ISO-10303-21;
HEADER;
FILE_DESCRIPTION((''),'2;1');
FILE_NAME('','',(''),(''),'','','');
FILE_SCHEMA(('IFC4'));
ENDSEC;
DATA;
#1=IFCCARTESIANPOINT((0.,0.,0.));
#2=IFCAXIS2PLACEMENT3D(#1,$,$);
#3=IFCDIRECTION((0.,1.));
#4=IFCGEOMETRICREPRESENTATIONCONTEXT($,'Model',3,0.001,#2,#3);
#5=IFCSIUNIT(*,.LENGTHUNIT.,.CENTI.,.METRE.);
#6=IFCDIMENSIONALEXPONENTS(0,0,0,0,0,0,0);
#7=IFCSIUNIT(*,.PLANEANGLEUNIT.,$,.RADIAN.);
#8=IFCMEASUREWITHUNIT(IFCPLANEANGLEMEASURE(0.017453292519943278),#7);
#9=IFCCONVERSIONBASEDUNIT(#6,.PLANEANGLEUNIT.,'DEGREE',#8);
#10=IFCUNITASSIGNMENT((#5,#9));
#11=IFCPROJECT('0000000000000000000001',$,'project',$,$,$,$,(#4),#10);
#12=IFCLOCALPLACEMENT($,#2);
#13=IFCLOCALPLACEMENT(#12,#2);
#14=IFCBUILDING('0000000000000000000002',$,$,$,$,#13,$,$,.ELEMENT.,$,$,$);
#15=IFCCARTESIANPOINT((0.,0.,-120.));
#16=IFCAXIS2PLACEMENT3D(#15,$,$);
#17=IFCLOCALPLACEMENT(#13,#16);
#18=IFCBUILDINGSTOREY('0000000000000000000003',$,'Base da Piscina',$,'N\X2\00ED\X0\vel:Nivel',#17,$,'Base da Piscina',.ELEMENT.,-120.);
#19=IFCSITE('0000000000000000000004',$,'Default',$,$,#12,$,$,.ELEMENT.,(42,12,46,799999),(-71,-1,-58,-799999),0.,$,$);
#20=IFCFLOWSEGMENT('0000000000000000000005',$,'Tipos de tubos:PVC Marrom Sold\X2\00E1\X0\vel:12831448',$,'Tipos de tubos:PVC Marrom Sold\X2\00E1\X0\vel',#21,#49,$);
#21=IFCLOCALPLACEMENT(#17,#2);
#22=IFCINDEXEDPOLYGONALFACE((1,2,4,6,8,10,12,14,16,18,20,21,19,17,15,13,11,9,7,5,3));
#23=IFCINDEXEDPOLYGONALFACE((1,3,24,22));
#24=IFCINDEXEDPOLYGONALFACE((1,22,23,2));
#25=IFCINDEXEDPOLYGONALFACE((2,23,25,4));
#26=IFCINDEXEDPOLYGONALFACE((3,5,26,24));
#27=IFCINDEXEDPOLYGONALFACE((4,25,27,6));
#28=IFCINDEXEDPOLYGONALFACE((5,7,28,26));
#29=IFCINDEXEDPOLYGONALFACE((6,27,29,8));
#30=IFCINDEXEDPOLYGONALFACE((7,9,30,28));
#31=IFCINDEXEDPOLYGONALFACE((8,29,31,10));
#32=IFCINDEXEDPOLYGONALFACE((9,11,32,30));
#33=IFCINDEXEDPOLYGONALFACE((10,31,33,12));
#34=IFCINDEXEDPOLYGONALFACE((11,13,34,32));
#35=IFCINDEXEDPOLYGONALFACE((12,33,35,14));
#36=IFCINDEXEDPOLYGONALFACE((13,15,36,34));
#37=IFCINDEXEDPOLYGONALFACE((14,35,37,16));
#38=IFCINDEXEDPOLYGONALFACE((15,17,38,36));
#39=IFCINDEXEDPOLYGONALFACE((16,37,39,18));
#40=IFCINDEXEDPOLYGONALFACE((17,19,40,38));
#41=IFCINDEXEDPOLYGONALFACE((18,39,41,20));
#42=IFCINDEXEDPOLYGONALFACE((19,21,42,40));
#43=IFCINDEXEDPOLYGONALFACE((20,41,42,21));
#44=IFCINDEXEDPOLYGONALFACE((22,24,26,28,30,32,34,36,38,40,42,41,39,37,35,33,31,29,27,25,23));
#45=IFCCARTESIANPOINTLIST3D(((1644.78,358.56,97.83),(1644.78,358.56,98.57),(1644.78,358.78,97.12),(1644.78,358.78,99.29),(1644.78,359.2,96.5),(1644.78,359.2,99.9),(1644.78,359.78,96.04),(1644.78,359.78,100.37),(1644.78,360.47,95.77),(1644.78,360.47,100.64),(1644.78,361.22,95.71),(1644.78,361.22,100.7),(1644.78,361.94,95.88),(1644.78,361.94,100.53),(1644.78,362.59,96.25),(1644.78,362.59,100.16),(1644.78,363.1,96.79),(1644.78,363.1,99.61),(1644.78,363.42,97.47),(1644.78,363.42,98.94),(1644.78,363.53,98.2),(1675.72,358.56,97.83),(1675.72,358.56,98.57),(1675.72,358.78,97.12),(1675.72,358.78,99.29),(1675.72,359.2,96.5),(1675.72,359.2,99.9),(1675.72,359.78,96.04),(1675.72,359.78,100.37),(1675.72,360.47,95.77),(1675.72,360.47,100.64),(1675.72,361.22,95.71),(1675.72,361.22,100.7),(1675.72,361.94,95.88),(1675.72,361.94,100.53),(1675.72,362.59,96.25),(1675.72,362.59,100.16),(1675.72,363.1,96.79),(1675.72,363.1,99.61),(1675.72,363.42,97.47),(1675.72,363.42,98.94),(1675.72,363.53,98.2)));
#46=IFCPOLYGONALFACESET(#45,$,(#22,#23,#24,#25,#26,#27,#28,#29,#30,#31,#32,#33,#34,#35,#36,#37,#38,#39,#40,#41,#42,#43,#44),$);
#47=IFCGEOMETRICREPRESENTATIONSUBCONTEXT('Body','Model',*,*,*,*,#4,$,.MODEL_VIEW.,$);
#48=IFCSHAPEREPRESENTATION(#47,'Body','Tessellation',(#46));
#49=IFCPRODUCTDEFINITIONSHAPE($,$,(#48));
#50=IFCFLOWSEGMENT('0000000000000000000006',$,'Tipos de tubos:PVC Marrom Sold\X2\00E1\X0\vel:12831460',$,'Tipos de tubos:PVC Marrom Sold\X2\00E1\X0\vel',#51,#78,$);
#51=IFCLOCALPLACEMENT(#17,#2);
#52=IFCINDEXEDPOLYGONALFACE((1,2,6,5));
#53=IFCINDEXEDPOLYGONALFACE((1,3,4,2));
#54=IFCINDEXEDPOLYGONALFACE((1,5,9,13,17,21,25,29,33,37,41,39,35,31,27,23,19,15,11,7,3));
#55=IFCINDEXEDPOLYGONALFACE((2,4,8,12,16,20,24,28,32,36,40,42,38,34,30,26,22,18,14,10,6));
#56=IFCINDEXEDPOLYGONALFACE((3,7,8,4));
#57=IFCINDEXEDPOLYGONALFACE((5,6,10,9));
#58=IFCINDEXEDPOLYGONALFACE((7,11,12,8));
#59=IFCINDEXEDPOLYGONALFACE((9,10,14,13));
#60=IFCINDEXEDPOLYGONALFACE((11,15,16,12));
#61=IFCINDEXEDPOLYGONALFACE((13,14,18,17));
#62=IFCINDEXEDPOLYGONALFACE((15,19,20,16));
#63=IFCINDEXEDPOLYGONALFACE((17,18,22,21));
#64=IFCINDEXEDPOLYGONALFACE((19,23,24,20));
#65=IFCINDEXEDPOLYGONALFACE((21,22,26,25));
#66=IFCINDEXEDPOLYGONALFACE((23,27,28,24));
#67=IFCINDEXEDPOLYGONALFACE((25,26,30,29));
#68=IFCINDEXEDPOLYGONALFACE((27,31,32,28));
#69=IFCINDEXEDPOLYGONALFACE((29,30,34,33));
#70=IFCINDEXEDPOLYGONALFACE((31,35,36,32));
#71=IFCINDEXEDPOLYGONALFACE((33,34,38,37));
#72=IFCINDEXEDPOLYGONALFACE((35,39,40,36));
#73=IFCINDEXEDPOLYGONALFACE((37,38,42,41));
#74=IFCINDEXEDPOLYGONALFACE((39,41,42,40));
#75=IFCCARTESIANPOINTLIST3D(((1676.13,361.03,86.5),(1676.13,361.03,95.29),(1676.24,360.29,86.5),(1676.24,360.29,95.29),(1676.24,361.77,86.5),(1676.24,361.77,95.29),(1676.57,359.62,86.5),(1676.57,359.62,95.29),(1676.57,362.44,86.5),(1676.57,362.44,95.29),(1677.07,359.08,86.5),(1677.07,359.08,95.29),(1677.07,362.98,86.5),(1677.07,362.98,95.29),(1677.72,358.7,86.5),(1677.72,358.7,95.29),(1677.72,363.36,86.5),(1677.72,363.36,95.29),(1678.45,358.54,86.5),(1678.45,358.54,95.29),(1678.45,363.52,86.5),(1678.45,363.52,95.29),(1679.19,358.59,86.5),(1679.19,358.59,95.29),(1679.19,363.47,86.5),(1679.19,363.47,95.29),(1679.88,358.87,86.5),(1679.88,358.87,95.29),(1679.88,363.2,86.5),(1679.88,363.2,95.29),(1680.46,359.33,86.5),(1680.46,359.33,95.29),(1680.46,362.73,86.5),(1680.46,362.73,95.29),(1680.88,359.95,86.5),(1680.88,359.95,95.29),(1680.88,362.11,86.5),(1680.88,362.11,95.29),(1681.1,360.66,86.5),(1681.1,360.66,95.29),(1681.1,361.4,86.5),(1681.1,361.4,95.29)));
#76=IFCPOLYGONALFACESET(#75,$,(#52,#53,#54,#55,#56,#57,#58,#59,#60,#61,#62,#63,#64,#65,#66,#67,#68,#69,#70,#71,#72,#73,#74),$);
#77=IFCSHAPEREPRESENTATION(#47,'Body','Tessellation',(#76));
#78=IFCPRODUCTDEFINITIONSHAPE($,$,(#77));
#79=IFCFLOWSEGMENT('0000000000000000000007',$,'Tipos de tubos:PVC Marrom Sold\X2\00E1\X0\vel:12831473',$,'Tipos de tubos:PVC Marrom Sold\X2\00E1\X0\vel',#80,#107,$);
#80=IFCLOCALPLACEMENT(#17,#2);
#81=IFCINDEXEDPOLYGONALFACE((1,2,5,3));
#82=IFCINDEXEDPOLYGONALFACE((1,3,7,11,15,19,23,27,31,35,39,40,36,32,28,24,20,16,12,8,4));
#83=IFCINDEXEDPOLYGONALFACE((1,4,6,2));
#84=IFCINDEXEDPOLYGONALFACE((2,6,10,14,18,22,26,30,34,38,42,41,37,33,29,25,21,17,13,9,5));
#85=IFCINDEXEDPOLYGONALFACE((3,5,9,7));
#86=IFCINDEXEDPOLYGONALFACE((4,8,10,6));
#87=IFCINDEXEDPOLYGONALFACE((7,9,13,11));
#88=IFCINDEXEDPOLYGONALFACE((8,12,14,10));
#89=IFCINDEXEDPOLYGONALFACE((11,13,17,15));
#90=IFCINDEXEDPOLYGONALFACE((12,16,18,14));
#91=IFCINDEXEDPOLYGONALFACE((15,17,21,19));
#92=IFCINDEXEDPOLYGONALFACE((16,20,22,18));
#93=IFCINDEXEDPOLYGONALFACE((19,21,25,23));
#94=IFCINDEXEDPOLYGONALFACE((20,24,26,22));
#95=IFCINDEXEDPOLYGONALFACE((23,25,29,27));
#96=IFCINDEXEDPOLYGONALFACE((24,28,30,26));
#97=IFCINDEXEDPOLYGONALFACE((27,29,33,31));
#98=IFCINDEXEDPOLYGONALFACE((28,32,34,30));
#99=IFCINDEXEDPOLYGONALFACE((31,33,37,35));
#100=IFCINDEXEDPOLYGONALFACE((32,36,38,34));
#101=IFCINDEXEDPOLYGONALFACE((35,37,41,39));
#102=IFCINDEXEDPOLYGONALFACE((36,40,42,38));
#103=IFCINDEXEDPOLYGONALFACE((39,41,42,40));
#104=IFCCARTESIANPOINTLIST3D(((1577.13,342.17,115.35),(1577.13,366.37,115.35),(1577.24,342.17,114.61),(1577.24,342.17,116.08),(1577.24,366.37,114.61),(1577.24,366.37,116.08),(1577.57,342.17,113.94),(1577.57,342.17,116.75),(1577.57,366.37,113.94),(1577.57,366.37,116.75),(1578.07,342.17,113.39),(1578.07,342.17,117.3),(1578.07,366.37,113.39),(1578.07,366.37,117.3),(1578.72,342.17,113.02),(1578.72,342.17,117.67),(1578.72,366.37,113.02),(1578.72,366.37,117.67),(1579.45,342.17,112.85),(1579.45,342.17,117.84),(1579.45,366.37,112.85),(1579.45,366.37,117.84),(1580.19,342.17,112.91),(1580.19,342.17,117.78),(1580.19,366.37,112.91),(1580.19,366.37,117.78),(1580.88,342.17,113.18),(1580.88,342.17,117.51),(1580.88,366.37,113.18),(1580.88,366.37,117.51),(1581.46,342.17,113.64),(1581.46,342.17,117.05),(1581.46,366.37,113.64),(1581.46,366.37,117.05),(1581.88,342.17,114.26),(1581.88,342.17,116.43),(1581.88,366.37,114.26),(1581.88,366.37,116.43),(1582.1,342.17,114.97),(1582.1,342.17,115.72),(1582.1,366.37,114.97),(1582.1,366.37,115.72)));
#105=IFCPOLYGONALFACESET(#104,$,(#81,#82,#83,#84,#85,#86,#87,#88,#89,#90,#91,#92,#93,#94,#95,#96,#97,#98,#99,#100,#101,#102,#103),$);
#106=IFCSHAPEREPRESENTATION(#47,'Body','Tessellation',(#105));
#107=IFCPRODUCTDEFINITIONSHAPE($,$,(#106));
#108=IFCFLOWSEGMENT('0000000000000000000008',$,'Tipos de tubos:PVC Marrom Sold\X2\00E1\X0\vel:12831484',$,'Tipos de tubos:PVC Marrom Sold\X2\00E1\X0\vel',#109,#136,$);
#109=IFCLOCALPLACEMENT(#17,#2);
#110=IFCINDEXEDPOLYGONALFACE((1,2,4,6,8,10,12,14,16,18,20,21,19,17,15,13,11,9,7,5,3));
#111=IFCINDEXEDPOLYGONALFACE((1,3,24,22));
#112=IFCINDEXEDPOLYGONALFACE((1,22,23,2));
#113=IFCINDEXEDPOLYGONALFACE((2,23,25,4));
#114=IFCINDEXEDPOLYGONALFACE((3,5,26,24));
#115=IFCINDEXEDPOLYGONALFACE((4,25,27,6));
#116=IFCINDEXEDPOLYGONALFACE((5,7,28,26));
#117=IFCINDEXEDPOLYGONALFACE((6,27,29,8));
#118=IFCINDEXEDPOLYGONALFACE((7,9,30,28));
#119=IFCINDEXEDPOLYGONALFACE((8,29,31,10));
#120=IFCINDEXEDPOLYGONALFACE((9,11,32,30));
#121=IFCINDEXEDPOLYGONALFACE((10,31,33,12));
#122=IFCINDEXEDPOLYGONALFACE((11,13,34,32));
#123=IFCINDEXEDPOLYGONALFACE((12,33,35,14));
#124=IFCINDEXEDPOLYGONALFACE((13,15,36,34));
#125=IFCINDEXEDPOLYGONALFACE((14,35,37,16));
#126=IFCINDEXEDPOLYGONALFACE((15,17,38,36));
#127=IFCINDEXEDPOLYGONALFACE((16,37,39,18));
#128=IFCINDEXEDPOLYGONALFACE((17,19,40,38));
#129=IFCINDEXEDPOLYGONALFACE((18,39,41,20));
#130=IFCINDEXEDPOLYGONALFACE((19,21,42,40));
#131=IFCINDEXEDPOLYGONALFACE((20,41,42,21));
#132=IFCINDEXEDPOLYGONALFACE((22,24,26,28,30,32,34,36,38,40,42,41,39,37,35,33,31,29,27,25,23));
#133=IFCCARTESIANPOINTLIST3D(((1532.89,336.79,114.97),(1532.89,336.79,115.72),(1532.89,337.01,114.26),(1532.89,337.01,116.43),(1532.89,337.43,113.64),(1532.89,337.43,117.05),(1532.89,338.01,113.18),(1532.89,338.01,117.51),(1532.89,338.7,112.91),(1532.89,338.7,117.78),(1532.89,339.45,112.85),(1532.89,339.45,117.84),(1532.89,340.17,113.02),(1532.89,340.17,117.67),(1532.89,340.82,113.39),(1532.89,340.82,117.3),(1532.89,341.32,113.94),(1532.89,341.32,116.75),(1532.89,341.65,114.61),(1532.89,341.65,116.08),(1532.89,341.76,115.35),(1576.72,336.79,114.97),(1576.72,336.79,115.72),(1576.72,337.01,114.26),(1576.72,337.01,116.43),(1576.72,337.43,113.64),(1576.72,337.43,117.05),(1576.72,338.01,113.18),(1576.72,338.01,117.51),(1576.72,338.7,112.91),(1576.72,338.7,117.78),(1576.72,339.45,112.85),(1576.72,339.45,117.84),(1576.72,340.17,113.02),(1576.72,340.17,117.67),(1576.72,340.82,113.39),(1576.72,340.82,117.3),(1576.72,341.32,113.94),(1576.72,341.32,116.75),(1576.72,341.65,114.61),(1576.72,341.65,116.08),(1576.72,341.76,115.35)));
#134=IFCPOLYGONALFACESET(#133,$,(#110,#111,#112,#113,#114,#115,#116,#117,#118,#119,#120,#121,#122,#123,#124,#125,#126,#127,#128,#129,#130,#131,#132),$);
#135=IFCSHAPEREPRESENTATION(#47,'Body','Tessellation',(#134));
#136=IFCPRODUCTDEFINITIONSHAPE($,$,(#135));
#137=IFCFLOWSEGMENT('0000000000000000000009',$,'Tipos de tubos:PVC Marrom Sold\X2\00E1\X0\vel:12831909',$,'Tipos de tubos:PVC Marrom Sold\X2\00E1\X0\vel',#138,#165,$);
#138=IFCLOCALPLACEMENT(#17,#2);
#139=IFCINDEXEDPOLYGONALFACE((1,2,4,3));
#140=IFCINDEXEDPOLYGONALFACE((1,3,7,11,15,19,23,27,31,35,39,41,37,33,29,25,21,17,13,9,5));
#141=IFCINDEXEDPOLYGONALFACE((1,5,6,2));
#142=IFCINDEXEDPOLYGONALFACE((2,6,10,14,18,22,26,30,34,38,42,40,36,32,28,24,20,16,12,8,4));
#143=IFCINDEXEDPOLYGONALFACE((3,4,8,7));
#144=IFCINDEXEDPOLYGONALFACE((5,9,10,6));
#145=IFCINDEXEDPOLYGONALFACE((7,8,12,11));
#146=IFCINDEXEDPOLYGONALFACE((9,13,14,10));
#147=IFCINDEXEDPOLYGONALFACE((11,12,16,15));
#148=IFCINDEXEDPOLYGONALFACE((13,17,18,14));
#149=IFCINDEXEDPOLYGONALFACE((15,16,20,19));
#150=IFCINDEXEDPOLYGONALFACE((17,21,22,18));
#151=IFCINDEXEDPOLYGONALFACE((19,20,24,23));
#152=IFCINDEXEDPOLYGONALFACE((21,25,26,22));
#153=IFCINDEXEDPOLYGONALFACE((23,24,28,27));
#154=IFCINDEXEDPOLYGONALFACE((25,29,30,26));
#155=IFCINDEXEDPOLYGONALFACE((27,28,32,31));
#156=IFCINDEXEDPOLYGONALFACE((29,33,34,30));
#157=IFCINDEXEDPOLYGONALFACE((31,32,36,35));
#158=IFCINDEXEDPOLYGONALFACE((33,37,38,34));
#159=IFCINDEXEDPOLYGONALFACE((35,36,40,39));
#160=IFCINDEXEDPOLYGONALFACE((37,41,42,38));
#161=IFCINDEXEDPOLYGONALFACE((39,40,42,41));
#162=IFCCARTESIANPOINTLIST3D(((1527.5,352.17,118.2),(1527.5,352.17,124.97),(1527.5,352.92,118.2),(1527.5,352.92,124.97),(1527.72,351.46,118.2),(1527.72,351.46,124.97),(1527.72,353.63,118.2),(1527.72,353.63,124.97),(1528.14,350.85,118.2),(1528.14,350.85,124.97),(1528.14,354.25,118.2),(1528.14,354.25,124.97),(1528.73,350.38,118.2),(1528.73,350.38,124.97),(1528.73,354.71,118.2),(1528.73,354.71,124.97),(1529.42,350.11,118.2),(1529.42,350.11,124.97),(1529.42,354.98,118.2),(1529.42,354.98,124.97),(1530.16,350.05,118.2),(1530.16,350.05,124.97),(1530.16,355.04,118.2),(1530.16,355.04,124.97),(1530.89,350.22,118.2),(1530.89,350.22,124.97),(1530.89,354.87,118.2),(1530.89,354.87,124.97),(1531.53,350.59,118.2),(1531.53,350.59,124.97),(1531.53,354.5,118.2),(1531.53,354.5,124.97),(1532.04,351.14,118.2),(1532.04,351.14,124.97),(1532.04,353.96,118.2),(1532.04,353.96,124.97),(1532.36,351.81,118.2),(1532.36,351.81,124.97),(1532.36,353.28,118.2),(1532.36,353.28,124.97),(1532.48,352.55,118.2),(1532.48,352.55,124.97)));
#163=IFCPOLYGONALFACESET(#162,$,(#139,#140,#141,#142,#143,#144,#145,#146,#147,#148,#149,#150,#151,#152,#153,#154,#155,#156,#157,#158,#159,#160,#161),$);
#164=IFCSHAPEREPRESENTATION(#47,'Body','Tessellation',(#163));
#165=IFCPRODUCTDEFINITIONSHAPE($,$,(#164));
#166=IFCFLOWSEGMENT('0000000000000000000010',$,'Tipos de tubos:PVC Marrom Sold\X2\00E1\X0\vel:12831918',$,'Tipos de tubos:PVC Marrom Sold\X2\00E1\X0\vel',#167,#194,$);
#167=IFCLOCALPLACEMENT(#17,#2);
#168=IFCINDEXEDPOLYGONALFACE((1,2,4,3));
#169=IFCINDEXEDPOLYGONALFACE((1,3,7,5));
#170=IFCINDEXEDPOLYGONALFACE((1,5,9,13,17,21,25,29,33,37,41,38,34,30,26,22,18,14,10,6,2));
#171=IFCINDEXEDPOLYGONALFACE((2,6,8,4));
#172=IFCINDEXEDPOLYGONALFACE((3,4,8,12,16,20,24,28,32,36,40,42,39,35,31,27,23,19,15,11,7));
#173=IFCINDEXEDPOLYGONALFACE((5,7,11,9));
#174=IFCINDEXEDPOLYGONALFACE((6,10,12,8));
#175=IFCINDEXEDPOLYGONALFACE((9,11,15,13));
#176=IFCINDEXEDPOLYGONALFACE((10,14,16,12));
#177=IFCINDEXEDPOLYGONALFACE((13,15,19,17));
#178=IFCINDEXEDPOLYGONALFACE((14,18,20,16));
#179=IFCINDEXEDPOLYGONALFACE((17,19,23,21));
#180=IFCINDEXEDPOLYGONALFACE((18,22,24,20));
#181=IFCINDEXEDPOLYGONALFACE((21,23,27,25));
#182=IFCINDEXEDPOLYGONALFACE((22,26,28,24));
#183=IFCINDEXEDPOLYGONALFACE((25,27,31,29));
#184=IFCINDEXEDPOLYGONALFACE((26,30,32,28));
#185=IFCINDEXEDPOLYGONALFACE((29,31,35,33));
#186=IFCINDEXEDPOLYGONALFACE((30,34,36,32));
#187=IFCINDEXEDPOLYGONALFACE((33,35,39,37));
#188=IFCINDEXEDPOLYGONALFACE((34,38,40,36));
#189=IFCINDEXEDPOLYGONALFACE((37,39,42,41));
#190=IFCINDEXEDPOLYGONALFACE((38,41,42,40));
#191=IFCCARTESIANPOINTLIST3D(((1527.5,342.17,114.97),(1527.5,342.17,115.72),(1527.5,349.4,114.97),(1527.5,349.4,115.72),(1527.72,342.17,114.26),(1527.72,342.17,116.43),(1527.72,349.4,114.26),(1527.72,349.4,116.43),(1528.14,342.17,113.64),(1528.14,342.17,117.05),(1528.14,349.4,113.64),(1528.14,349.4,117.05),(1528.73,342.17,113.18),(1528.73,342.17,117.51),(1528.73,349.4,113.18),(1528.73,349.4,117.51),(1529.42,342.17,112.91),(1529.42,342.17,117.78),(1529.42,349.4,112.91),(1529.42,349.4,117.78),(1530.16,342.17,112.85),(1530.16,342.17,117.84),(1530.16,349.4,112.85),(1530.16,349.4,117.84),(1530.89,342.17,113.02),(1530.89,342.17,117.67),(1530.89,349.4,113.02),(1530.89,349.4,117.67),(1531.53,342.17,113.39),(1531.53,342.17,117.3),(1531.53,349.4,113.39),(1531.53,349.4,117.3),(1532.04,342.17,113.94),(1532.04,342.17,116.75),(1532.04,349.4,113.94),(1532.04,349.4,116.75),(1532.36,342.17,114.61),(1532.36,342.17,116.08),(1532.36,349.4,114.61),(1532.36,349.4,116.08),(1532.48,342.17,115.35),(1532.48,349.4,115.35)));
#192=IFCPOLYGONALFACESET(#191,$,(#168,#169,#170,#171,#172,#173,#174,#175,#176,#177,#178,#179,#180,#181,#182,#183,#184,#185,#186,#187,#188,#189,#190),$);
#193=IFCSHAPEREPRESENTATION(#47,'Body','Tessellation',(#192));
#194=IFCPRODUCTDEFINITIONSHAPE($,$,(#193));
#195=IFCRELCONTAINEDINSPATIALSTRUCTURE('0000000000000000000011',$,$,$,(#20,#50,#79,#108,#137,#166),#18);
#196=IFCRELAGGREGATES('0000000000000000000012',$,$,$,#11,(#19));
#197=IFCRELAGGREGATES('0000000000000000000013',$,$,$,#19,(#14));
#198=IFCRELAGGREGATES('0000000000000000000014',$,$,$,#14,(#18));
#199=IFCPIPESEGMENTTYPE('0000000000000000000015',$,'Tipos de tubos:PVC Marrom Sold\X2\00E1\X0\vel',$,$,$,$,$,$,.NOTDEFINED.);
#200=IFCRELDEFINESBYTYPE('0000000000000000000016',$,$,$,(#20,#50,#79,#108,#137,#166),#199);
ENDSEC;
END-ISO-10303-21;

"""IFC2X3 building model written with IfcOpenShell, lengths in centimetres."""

from ifc_helpers import new_model, entity, si_unit, converted_unit, direction, frame, frame_2d, origin, origin_2d_with_axis, place, context, subcontext, project, spatial, circle, extrude, type_object, element, save


model = new_model("IFC2X3")

# Units and contexts
model_context = context("Model", 3, precision=0.001, world=origin(), true_north=direction((0.0, 1.0)))
body_context = subcontext(model_context, "Body", "Model", "MODEL_VIEW")
ifc_project = project(units=[si_unit("LENGTHUNIT", "METRE", prefix="CENTI"), converted_unit("PLANEANGLEUNIT", "DEGREE", entity("IfcPlaneAngleMeasure", 0.017453292519943278), si_unit("PLANEANGLEUNIT", "RADIAN"), dimensions=[0, 0, 0, 0, 0, 0, 0])], contexts=[model_context])

# Site, building, storey
site_placement = place(None, origin())
site = spatial("IfcSite", under=ifc_project, at=site_placement, Name="Default", CompositionType="ELEMENT", RefLatitude=(42, 12, 46, 799999), RefLongitude=(-71, -1, -58, -799999), RefElevation=0.0)
building_placement = place(site_placement, origin())
building = spatial("IfcBuilding", under=site, at=building_placement, CompositionType="ELEMENT")
storey_placement = place(building_placement, frame((0.0, 0.0, -120.0)))
storey = spatial("IfcBuildingStorey", under=building, at=storey_placement, Name="Base da Piscina", ObjectType="Nível:Nivel", LongName="Base da Piscina", CompositionType="ELEMENT", Elevation=-120.0)

# Flow segments
pipe_segment_type = type_object("IfcPipeSegmentType", Name="Tipos de tubos:PVC Marrom Soldável", PredefinedType="NOTDEFINED")
flow_segment_1_placement = place(storey_placement, origin())
element("IfcFlowSegment", 1, at=flow_segment_1_placement, inside=storey, type_object=pipe_segment_type, Name="Tipos de tubos:PVC Marrom Soldável:12831448", ObjectType="Tipos de tubos:PVC Marrom Soldável", context=body_context, shape_type="SweptSolid", body=[
    extrude(circle(Radius=2.5, at=origin_2d_with_axis()), frame((1644.78, 361.03, 98.2), z_axis=(1.0, 0.0, 0.0), x_axis=(0.0, 1.0, 0.0)), (0.0, 0.0, 1.0), 30.94),
])
flow_segment_2_placement = place(storey_placement, origin())
element("IfcFlowSegment", 2, at=flow_segment_2_placement, inside=storey, type_object=pipe_segment_type, Name="Tipos de tubos:PVC Marrom Soldável:12831460", ObjectType="Tipos de tubos:PVC Marrom Soldável", context=body_context, shape_type="SweptSolid", body=[
    extrude(circle(Radius=2.5, at=frame_2d((0.0, 0.0), x_axis=(1.0, 0.0))), frame((1678.63, 361.03, 86.5), z_axis=(0.0, 0.0, 1.0), x_axis=(-1.0, 0.0, 0.0)), (0.0, 0.0, 1.0), 8.8),
])
flow_segment_3_placement = place(storey_placement, origin())
element("IfcFlowSegment", 3, at=flow_segment_3_placement, inside=storey, type_object=pipe_segment_type, Name="Tipos de tubos:PVC Marrom Soldável:12831473", ObjectType="Tipos de tubos:PVC Marrom Soldável", context=body_context, shape_type="SweptSolid", body=[
    extrude(circle(Radius=2.5, at=frame_2d((0.0, 0.0), x_axis=(1.0, 0.0))), frame((1579.63, 342.17, 115.35), z_axis=(0.0, 1.0, 0.0), x_axis=(-1.0, 0.0, 0.0)), (0.0, 0.0, 1.0), 24.2),
])
flow_segment_4_placement = place(storey_placement, origin())
element("IfcFlowSegment", 4, at=flow_segment_4_placement, inside=storey, type_object=pipe_segment_type, Name="Tipos de tubos:PVC Marrom Soldável:12831484", ObjectType="Tipos de tubos:PVC Marrom Soldável", context=body_context, shape_type="SweptSolid", body=[
    extrude(circle(Radius=2.5, at=frame_2d((0.0, 0.0), x_axis=(1.0, 0.0))), frame((1532.89, 339.26, 115.35), z_axis=(1.0, 0.0, 0.0), x_axis=(0.0, 1.0, 0.0)), (0.0, 0.0, 1.0), 43.84),
])
flow_segment_5_placement = place(storey_placement, origin())
element("IfcFlowSegment", 5, at=flow_segment_5_placement, inside=storey, type_object=pipe_segment_type, Name="Tipos de tubos:PVC Marrom Soldável:12831909", ObjectType="Tipos de tubos:PVC Marrom Soldável", context=body_context, shape_type="SweptSolid", body=[
    extrude(circle(Radius=2.5, at=origin_2d_with_axis()), frame((1529.98, 352.55, 118.2)), (0.0, 0.0, 1.0), 6.78),
])
flow_segment_6_placement = place(storey_placement, origin())
element("IfcFlowSegment", 6, at=flow_segment_6_placement, inside=storey, type_object=pipe_segment_type, Name="Tipos de tubos:PVC Marrom Soldável:12831918", ObjectType="Tipos de tubos:PVC Marrom Soldável", context=body_context, shape_type="SweptSolid", body=[
    extrude(circle(Radius=2.5, at=frame_2d((0.0, 0.0), x_axis=(1.0, 0.0))), frame((1529.98, 342.17, 115.35), z_axis=(0.0, 1.0, 0.0), x_axis=(1.0, 0.0, 0.0)), (0.0, 0.0, 1.0), 7.23),
])

save(model, "model.ifc")
